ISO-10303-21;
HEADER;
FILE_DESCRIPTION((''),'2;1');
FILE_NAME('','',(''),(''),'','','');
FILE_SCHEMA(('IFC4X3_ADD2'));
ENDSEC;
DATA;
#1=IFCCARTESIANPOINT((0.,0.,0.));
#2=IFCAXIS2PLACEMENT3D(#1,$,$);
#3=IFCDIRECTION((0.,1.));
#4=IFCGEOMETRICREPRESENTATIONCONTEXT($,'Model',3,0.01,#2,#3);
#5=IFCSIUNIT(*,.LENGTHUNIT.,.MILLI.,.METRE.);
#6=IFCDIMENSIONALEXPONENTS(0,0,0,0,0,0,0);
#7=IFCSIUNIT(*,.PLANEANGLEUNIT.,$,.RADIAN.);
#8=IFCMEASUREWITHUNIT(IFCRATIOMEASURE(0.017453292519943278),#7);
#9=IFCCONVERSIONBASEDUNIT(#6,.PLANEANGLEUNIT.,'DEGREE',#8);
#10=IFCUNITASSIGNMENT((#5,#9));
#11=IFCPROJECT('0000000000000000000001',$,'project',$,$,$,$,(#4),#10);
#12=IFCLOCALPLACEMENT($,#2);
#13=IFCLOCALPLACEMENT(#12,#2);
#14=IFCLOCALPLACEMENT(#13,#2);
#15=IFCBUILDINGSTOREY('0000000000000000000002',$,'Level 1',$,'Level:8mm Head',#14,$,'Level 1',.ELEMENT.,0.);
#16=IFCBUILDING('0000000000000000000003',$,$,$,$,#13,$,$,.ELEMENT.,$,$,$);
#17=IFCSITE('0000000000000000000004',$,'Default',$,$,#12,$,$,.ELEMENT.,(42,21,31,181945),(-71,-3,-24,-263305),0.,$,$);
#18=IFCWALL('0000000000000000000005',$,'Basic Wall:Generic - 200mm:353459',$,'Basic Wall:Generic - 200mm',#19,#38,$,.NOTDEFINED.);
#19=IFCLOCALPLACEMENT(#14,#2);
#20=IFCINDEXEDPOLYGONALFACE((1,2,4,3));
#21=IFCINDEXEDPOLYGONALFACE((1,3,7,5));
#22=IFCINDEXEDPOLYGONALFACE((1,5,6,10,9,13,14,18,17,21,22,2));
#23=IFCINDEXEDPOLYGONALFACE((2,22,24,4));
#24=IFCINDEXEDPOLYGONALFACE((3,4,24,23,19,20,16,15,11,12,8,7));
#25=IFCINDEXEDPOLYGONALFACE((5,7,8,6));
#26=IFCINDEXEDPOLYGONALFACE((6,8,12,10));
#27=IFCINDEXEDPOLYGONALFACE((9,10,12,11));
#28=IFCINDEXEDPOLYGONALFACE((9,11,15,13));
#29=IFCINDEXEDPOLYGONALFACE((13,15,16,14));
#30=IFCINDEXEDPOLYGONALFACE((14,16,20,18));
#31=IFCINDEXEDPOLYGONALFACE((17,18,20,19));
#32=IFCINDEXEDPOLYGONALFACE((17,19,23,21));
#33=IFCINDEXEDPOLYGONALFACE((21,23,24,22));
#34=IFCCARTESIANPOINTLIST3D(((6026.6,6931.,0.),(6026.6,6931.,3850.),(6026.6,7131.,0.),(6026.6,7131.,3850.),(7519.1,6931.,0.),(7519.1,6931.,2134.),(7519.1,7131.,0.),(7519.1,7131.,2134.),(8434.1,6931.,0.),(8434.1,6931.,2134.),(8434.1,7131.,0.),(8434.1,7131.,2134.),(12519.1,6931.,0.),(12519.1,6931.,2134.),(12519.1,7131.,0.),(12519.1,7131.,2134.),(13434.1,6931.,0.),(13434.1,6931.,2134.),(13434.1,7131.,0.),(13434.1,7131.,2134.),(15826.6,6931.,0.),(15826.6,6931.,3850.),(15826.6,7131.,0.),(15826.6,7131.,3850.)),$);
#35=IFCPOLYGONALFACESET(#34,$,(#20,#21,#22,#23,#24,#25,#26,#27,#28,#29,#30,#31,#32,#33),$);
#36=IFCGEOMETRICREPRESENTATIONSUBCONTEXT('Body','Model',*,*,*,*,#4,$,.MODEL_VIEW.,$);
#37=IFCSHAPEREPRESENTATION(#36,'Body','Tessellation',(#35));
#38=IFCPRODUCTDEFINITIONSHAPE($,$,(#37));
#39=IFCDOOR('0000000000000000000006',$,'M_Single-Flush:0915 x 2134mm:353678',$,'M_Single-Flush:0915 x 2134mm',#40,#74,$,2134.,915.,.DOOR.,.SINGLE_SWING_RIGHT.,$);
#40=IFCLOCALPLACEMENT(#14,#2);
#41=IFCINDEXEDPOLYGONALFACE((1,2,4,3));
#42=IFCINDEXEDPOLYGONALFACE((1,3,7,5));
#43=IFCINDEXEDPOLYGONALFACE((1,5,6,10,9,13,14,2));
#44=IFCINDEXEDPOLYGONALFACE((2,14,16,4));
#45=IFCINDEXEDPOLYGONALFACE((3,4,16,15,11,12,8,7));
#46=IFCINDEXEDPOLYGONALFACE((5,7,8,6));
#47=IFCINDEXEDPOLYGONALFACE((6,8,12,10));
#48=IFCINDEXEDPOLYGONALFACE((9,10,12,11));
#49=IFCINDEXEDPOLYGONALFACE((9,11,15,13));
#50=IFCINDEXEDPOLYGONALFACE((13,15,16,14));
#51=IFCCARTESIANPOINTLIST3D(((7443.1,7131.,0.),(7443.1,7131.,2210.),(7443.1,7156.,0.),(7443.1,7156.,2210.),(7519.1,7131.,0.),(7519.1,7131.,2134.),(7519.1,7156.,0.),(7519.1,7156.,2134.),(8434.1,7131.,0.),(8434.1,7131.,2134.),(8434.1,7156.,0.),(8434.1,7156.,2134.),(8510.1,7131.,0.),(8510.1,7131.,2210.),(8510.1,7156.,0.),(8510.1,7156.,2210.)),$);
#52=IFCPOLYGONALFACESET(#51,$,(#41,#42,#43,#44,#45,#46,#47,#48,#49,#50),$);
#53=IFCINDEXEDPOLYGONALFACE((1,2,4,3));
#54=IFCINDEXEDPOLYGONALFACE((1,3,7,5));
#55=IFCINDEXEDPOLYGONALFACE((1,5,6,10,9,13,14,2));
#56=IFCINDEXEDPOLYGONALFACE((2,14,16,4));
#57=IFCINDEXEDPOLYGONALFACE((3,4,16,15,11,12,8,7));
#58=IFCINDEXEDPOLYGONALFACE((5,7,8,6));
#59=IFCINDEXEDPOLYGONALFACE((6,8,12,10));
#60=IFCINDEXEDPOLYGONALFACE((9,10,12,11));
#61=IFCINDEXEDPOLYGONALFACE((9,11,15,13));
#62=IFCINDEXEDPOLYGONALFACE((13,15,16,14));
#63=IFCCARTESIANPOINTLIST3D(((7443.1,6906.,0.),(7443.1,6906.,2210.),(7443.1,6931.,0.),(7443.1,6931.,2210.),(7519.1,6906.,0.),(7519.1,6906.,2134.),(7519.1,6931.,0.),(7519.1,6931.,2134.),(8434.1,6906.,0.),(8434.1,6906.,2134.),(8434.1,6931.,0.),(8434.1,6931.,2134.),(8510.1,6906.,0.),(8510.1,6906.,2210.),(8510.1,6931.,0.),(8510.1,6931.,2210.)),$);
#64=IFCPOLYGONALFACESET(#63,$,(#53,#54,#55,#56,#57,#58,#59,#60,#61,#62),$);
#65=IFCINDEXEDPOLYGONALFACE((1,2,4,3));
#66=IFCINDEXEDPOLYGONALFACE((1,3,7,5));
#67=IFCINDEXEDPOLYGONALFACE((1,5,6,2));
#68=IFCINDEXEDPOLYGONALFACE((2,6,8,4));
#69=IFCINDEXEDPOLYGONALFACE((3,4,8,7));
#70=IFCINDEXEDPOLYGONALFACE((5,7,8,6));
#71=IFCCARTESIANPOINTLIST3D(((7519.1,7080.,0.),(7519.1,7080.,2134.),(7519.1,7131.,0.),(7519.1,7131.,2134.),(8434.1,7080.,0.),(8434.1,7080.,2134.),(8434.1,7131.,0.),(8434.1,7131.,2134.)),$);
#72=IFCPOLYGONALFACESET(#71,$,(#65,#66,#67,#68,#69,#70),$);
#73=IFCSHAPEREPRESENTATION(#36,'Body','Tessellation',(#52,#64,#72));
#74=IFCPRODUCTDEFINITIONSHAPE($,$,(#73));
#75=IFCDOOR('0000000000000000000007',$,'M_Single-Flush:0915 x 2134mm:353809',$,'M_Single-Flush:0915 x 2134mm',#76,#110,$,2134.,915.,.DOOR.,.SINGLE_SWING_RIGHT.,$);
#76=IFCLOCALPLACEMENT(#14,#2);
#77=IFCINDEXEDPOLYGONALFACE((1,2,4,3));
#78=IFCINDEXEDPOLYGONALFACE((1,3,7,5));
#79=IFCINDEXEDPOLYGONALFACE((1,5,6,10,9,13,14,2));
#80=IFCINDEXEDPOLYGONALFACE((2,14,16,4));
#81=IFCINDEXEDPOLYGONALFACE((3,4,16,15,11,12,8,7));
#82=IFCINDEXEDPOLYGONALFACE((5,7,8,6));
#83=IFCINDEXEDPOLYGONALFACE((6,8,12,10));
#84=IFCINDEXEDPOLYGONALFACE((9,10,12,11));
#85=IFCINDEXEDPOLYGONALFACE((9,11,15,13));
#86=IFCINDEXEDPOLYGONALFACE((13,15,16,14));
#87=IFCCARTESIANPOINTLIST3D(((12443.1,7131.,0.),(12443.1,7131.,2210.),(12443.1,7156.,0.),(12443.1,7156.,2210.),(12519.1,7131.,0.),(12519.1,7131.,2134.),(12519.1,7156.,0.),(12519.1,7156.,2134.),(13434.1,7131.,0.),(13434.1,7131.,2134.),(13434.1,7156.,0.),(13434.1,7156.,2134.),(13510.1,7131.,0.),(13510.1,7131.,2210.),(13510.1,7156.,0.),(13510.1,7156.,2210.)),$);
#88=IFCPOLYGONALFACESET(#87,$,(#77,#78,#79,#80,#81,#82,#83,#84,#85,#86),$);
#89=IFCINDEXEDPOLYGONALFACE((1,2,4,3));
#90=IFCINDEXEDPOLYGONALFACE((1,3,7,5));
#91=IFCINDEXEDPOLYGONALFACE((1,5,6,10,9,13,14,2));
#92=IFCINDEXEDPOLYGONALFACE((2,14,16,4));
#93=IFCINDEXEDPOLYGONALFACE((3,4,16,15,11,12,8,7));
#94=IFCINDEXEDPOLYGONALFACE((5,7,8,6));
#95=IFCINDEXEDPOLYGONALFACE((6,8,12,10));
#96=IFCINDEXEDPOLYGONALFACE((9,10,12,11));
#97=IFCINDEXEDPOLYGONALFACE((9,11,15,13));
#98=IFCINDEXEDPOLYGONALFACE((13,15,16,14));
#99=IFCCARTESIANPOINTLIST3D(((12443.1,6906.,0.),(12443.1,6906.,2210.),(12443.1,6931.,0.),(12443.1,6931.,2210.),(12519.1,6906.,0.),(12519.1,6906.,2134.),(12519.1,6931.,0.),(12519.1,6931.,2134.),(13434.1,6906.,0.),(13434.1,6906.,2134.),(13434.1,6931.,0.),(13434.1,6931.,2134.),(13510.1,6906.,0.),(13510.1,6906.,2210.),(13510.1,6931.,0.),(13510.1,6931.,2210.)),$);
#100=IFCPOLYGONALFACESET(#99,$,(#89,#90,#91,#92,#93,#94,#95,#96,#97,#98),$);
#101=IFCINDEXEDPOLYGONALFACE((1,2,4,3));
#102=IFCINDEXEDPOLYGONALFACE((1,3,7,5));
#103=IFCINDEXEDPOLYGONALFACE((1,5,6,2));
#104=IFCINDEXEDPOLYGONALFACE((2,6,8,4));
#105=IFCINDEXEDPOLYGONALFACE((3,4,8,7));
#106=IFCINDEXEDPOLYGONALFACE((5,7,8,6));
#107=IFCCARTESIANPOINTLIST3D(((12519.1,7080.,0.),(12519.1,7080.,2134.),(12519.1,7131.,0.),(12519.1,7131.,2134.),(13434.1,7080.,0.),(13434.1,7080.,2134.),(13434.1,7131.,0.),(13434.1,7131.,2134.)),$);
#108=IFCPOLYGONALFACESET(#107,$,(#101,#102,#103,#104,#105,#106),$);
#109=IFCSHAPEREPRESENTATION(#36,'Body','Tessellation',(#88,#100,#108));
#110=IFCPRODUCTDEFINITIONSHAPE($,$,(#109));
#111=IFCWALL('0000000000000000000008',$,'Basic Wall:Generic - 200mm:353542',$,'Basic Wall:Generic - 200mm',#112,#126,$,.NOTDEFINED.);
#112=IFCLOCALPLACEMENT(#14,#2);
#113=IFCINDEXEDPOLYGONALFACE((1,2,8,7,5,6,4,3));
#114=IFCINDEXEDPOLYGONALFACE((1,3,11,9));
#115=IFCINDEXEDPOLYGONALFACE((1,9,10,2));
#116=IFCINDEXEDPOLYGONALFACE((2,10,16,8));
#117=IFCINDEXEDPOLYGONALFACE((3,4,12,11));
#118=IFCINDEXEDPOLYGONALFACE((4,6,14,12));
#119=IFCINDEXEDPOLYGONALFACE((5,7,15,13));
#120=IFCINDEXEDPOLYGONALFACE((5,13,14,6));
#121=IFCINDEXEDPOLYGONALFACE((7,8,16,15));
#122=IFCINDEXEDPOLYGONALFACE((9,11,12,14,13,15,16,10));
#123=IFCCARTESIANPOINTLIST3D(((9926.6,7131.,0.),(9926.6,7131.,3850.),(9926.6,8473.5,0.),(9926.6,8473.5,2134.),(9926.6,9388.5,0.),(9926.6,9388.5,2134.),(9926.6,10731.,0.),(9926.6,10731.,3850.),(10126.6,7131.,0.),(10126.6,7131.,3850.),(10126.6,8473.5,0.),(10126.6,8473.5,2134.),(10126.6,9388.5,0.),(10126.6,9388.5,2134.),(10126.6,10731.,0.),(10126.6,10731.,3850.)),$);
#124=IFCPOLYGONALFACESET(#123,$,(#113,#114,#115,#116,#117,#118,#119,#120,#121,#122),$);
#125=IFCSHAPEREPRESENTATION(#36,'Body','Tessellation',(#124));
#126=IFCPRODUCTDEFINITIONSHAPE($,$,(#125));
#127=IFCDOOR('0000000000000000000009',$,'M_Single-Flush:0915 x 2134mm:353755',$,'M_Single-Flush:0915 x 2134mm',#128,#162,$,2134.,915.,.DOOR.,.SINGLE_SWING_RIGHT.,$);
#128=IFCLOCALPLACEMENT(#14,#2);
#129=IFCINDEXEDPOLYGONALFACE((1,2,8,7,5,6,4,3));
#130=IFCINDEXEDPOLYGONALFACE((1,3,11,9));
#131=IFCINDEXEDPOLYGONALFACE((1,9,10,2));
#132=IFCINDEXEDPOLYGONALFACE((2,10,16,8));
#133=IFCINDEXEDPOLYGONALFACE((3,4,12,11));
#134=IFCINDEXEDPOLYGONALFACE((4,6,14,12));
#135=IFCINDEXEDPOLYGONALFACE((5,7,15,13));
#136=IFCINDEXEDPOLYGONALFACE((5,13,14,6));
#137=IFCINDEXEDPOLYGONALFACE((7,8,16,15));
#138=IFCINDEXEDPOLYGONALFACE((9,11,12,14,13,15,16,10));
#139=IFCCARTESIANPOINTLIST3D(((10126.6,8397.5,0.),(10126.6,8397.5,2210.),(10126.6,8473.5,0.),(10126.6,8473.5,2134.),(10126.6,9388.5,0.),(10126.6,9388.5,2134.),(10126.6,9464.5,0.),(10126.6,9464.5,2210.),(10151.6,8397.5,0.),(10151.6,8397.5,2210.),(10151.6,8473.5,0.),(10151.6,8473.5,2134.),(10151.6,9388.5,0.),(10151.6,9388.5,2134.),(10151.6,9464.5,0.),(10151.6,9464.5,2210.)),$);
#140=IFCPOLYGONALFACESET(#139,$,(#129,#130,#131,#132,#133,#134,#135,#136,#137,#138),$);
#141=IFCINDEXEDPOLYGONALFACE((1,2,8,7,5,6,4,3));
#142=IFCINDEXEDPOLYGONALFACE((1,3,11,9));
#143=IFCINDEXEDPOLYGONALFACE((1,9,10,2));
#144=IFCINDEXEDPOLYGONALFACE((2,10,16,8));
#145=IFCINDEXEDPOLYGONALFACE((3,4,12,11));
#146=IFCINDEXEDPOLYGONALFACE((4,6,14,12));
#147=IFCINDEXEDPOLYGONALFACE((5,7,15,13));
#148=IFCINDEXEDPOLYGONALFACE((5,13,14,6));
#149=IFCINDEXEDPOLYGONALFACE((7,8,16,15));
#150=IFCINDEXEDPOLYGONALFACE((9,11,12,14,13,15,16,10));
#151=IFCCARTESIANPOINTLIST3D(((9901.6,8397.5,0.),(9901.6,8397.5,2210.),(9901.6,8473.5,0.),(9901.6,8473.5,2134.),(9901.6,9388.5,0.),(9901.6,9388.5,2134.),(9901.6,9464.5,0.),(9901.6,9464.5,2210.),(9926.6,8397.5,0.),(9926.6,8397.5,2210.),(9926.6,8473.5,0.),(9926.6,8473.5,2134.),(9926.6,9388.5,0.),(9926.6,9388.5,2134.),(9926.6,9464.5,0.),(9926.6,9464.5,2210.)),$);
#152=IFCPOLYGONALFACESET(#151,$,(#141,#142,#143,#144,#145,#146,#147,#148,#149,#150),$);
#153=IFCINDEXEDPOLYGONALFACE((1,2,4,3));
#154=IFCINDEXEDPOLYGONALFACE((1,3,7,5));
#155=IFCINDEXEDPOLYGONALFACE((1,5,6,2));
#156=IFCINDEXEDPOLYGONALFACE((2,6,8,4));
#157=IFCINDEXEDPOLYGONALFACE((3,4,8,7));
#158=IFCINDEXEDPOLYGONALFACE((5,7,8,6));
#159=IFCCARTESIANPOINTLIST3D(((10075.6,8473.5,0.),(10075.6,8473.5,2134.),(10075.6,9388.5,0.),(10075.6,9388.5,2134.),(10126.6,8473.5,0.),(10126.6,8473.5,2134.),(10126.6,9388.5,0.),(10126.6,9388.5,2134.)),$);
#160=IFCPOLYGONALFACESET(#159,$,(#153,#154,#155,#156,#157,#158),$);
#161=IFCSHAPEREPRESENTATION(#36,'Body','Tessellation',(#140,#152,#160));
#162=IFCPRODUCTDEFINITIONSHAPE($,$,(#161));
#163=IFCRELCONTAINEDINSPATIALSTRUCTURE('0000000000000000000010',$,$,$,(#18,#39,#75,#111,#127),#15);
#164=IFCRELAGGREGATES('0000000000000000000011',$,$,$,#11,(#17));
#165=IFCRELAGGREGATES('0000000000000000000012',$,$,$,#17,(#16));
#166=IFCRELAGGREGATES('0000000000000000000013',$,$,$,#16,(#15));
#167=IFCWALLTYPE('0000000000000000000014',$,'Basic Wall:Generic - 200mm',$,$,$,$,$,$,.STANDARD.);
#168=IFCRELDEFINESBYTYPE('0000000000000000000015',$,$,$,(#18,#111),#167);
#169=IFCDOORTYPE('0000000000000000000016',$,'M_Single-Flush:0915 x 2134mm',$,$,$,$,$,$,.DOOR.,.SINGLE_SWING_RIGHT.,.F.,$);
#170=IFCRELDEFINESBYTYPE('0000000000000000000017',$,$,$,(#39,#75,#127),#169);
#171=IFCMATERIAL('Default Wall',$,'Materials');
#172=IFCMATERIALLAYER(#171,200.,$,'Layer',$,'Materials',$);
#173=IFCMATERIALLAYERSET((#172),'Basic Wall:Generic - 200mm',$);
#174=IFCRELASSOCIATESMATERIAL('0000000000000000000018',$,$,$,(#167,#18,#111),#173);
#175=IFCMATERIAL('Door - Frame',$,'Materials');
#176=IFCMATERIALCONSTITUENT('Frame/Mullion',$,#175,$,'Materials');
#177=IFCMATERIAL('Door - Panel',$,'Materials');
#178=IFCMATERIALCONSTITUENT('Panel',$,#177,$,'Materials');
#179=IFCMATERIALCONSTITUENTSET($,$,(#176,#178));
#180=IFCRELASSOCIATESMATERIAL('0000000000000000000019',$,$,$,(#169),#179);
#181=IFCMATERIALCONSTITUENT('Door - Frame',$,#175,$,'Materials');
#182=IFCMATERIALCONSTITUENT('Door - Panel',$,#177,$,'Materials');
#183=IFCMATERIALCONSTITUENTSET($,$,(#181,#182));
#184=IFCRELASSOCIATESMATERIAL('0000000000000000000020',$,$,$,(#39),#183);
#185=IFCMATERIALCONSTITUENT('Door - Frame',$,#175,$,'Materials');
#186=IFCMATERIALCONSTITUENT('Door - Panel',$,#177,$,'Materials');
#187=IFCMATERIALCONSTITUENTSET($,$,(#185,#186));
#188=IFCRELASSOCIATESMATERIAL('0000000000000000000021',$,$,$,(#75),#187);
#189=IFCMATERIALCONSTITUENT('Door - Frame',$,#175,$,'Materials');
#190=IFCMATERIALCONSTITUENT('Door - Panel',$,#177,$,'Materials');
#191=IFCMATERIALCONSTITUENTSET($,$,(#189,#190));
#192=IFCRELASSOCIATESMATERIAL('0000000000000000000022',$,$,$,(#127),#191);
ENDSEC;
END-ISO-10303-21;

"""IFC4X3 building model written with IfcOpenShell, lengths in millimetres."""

from ifc_helpers import new_model, entity, si_unit, converted_unit, direction, frame, frame_2d, origin, place, context, subcontext, project, spatial, polyline, rectangle, outline, extrude, clip, bounded_halfspace, source, transform, mapped, material, layer, layer_set, constituent, constituent_set, type_object, type_shapes, element, fill, save


model = new_model("IFC4X3")

# Units and contexts
model_context = context("Model", 3, precision=0.01, world=origin(), true_north=direction((0.0, 1.0)))
body_context = subcontext(model_context, "Body", "Model", "MODEL_VIEW")
ifc_project = project(units=[si_unit("LENGTHUNIT", "METRE", prefix="MILLI"), converted_unit("PLANEANGLEUNIT", "DEGREE", entity("IfcRatioMeasure", 0.017453292519943278), si_unit("PLANEANGLEUNIT", "RADIAN"), dimensions=[0, 0, 0, 0, 0, 0, 0])], contexts=[model_context])

# Site, building, storey
site_placement = place(None, origin())
site = spatial("IfcSite", under=ifc_project, at=site_placement, Name="Default", CompositionType="ELEMENT", RefLatitude=(42, 21, 31, 181945), RefLongitude=(-71, -3, -24, -263305), RefElevation=0.0)
building_placement = place(site_placement, origin())
building = spatial("IfcBuilding", under=site, at=building_placement, CompositionType="ELEMENT")
storey_placement = place(building_placement, origin())
storey = spatial("IfcBuildingStorey", under=building, at=storey_placement, Name="Level 1", ObjectType="Level:8mm Head", LongName="Level 1", CompositionType="ELEMENT", Elevation=0.0)

# Shared definitions
ifc_material_1 = material(Name="Default Wall", Category="Materials")
ifc_layer_1 = layer(ifc_material_1, 200.0, Name="Layer", Category="Materials")
ifc_layer_set_1 = layer_set([ifc_layer_1], Name="Basic Wall:Generic - 200mm")
wall_type = type_object("IfcWallType", Name="Basic Wall:Generic - 200mm", PredefinedType="STANDARD", material=ifc_layer_set_1)
ifc_material_2 = material(Name="Door - Frame", Category="Materials")
ifc_material_3 = material(Name="Door - Panel", Category="Materials")
ifc_constituent_1 = constituent(ifc_material_2, Name="Frame/Mullion", Category="Materials")
ifc_constituent_2 = constituent(ifc_material_3, Name="Panel", Category="Materials")
ifc_constituent_set_1 = constituent_set(constituents=[ifc_constituent_1, ifc_constituent_2])
door_type = type_object("IfcDoorType", Name="M_Single-Flush:0915 x 2134mm", OperationType="SINGLE_SWING_RIGHT", ParameterTakesPrecedence=False, PredefinedType="DOOR", material=ifc_constituent_set_1)
shared_shape = source(origin(), body_context, "Body", "SweptSolid", [
    extrude(outline(polyline([(-533.5, -1124.0), (533.5, -1124.0), (533.5, 1086.0), (457.5, 1086.0), (457.5, -1048.0), (-457.5, -1048.0), (-457.5, 1086.0), (-533.5, 1086.0), (-533.5, -1124.0)])), frame((457.5, 200.0, 1086.0), z_axis=(0.0, 1.0, 0.0), x_axis=(1.0, 0.0, 0.0)), (0.0, 0.0, 1.0), 25.0),
    extrude(outline(polyline([(-1124.0, -533.5), (1086.0, -533.5), (1086.0, -457.5), (-1048.0, -457.5), (-1048.0, 457.5), (1086.0, 457.5), (1086.0, 533.5), (-1124.0, 533.5), (-1124.0, -533.5)])), frame((457.5, -25.0, 1086.0), z_axis=(0.0, 1.0, 0.0), x_axis=(0.0, 0.0, -1.0)), (0.0, 0.0, 1.0), 25.0),
    extrude(rectangle(XDim=51.0, YDim=915.0, at=frame_2d((0.0, 0.0), x_axis=(1.0, 0.0))), frame((457.5, 174.5, 0.0), z_axis=(0.0, 0.0, 1.0), x_axis=(0.0, 1.0, 0.0)), (0.0, 0.0, 1.0), 2134.0),
])
type_shapes(door_type, [shared_shape])

# Wall, openings, doors
wall_1_placement = place(storey_placement, frame((6026.6, 7031.0, 0.0)))
wall_1 = element("IfcWall", 1, at=wall_1_placement, inside=storey, type_object=wall_type, material=ifc_layer_set_1, Name="Basic Wall:Generic - 200mm:353459", ObjectType="Basic Wall:Generic - 200mm", PredefinedType="NOTDEFINED", context=body_context, shape_type="Clipping", body=[
    clip(extrude(rectangle(XDim=9800.0, YDim=200.0, at=frame_2d((4900.0, 0.0), x_axis=(-1.0, 0.0))), origin(), (0.0, 0.0, 1.0), 3850.0), bounded_halfspace(frame((0.0, -100.0, 3850.0), z_axis=(0.0, 0.0, -1.0), x_axis=(1.0, 0.0, 0.0)), True, frame((0.0, -100.0, 3850.0)), polyline([(0.0, 0.0), (9800.0, 0.0), (9800.0, 200.0), (4100.0, 200.0), (3900.0, 200.0), (0.0, 200.0), (0.0, 0.0)]))),
])
opening_1_placement = place(wall_1_placement, frame((1492.5, -100.0, 0.0)))
opening_1 = element("IfcOpeningElement", 2, at=opening_1_placement, cuts=wall_1, PredefinedType="OPENING", context=body_context, shape_type="SweptSolid", body=[
    extrude(rectangle(XDim=915.0, YDim=2134.0, at=frame_2d((1067.0, 457.5), x_axis=(0.0, 1.0))), frame((0.0, 0.0, 0.0), z_axis=(0.0, 1.0, 0.0), x_axis=(0.0, 0.0, 1.0)), (0.0, 0.0, 1.0), 200.0),
])
opening_2_placement = place(wall_1_placement, frame((6492.5, -100.0, 0.0)))
opening_2 = element("IfcOpeningElement", 3, at=opening_2_placement, cuts=wall_1, PredefinedType="OPENING", context=body_context, shape_type="SweptSolid", body=[
    extrude(rectangle(XDim=915.0, YDim=2134.0, at=frame_2d((1067.0, 457.5), x_axis=(0.0, 1.0))), frame((0.0, 0.0, 0.0), z_axis=(0.0, 1.0, 0.0), x_axis=(0.0, 0.0, 1.0)), (0.0, 0.0, 1.0), 200.0),
])
ifc_constituent_3 = constituent(ifc_material_2, Name="Door - Frame", Category="Materials")
ifc_constituent_4 = constituent(ifc_material_3, Name="Door - Panel", Category="Materials")
ifc_constituent_set_2 = constituent_set(constituents=[ifc_constituent_3, ifc_constituent_4])
door_1_placement = place(opening_1_placement, origin())
door_1 = element("IfcDoor", 4, at=door_1_placement, inside=storey, type_object=door_type, material=ifc_constituent_set_2, Name="M_Single-Flush:0915 x 2134mm:353678", ObjectType="M_Single-Flush:0915 x 2134mm", OperationType="SINGLE_SWING_RIGHT", OverallHeight=2134.0, OverallWidth=915.0, PredefinedType="DOOR", context=body_context, shape_type="MappedRepresentation", body=[
    mapped(shared_shape, transform((0.0, 0.0, 0.0), scale=1.0)),
])
fill(opening_1, door_1)
ifc_constituent_5 = constituent(ifc_material_2, Name="Door - Frame", Category="Materials")
ifc_constituent_6 = constituent(ifc_material_3, Name="Door - Panel", Category="Materials")
ifc_constituent_set_3 = constituent_set(constituents=[ifc_constituent_5, ifc_constituent_6])
door_2_placement = place(opening_2_placement, origin())
door_2 = element("IfcDoor", 5, at=door_2_placement, inside=storey, type_object=door_type, material=ifc_constituent_set_3, Name="M_Single-Flush:0915 x 2134mm:353809", ObjectType="M_Single-Flush:0915 x 2134mm", OperationType="SINGLE_SWING_RIGHT", OverallHeight=2134.0, OverallWidth=915.0, PredefinedType="DOOR", context=body_context, shape_type="MappedRepresentation", body=[
    mapped(shared_shape, transform((0.0, 0.0, 0.0), scale=1.0)),
])
fill(opening_2, door_2)

# Wall, opening, door
wall_2_placement = place(storey_placement, frame((10026.6, 10731.0, 0.0), z_axis=(0.0, 0.0, 1.0), x_axis=(0.0, -1.0, 0.0)))
wall_2 = element("IfcWall", 6, at=wall_2_placement, inside=storey, type_object=wall_type, material=ifc_layer_set_1, Name="Basic Wall:Generic - 200mm:353542", ObjectType="Basic Wall:Generic - 200mm", PredefinedType="NOTDEFINED", context=body_context, shape_type="Clipping", body=[
    clip(extrude(rectangle(XDim=3600.0, YDim=200.0, at=frame_2d((1800.0, 0.0), x_axis=(1.0, 0.0))), origin(), (0.0, 0.0, 1.0), 3850.0), bounded_halfspace(frame((0.0, -100.0, 3850.0), z_axis=(0.0, 0.0, -1.0), x_axis=(0.0, 1.0, 0.0)), True, frame((0.0, -100.0, 3850.0)), polyline([(0.0, 0.0), (3600.0, 0.0), (3600.0, 200.0), (0.0, 200.0), (0.0, 0.0)]))),
])
opening_3_placement = place(wall_2_placement, frame((1342.5, -100.0, 0.0)))
opening_3 = element("IfcOpeningElement", 7, at=opening_3_placement, cuts=wall_2, PredefinedType="OPENING", context=body_context, shape_type="SweptSolid", body=[
    extrude(rectangle(XDim=915.0, YDim=2134.0, at=frame_2d((1067.0, 457.5), x_axis=(0.0, 1.0))), frame((0.0, 0.0, 0.0), z_axis=(0.0, 1.0, 0.0), x_axis=(0.0, 0.0, 1.0)), (0.0, 0.0, 1.0), 200.0),
])
ifc_constituent_7 = constituent(ifc_material_2, Name="Door - Frame", Category="Materials")
ifc_constituent_8 = constituent(ifc_material_3, Name="Door - Panel", Category="Materials")
ifc_constituent_set_4 = constituent_set(constituents=[ifc_constituent_7, ifc_constituent_8])
door_3_placement = place(opening_3_placement, origin())
door_3 = element("IfcDoor", 8, at=door_3_placement, inside=storey, type_object=door_type, material=ifc_constituent_set_4, Name="M_Single-Flush:0915 x 2134mm:353755", ObjectType="M_Single-Flush:0915 x 2134mm", OperationType="SINGLE_SWING_RIGHT", OverallHeight=2134.0, OverallWidth=915.0, PredefinedType="DOOR", context=body_context, shape_type="MappedRepresentation", body=[
    mapped(shared_shape, transform((0.0, 0.0, 0.0), scale=1.0)),
])
fill(opening_3, door_3)

save(model, "model.ifc")
